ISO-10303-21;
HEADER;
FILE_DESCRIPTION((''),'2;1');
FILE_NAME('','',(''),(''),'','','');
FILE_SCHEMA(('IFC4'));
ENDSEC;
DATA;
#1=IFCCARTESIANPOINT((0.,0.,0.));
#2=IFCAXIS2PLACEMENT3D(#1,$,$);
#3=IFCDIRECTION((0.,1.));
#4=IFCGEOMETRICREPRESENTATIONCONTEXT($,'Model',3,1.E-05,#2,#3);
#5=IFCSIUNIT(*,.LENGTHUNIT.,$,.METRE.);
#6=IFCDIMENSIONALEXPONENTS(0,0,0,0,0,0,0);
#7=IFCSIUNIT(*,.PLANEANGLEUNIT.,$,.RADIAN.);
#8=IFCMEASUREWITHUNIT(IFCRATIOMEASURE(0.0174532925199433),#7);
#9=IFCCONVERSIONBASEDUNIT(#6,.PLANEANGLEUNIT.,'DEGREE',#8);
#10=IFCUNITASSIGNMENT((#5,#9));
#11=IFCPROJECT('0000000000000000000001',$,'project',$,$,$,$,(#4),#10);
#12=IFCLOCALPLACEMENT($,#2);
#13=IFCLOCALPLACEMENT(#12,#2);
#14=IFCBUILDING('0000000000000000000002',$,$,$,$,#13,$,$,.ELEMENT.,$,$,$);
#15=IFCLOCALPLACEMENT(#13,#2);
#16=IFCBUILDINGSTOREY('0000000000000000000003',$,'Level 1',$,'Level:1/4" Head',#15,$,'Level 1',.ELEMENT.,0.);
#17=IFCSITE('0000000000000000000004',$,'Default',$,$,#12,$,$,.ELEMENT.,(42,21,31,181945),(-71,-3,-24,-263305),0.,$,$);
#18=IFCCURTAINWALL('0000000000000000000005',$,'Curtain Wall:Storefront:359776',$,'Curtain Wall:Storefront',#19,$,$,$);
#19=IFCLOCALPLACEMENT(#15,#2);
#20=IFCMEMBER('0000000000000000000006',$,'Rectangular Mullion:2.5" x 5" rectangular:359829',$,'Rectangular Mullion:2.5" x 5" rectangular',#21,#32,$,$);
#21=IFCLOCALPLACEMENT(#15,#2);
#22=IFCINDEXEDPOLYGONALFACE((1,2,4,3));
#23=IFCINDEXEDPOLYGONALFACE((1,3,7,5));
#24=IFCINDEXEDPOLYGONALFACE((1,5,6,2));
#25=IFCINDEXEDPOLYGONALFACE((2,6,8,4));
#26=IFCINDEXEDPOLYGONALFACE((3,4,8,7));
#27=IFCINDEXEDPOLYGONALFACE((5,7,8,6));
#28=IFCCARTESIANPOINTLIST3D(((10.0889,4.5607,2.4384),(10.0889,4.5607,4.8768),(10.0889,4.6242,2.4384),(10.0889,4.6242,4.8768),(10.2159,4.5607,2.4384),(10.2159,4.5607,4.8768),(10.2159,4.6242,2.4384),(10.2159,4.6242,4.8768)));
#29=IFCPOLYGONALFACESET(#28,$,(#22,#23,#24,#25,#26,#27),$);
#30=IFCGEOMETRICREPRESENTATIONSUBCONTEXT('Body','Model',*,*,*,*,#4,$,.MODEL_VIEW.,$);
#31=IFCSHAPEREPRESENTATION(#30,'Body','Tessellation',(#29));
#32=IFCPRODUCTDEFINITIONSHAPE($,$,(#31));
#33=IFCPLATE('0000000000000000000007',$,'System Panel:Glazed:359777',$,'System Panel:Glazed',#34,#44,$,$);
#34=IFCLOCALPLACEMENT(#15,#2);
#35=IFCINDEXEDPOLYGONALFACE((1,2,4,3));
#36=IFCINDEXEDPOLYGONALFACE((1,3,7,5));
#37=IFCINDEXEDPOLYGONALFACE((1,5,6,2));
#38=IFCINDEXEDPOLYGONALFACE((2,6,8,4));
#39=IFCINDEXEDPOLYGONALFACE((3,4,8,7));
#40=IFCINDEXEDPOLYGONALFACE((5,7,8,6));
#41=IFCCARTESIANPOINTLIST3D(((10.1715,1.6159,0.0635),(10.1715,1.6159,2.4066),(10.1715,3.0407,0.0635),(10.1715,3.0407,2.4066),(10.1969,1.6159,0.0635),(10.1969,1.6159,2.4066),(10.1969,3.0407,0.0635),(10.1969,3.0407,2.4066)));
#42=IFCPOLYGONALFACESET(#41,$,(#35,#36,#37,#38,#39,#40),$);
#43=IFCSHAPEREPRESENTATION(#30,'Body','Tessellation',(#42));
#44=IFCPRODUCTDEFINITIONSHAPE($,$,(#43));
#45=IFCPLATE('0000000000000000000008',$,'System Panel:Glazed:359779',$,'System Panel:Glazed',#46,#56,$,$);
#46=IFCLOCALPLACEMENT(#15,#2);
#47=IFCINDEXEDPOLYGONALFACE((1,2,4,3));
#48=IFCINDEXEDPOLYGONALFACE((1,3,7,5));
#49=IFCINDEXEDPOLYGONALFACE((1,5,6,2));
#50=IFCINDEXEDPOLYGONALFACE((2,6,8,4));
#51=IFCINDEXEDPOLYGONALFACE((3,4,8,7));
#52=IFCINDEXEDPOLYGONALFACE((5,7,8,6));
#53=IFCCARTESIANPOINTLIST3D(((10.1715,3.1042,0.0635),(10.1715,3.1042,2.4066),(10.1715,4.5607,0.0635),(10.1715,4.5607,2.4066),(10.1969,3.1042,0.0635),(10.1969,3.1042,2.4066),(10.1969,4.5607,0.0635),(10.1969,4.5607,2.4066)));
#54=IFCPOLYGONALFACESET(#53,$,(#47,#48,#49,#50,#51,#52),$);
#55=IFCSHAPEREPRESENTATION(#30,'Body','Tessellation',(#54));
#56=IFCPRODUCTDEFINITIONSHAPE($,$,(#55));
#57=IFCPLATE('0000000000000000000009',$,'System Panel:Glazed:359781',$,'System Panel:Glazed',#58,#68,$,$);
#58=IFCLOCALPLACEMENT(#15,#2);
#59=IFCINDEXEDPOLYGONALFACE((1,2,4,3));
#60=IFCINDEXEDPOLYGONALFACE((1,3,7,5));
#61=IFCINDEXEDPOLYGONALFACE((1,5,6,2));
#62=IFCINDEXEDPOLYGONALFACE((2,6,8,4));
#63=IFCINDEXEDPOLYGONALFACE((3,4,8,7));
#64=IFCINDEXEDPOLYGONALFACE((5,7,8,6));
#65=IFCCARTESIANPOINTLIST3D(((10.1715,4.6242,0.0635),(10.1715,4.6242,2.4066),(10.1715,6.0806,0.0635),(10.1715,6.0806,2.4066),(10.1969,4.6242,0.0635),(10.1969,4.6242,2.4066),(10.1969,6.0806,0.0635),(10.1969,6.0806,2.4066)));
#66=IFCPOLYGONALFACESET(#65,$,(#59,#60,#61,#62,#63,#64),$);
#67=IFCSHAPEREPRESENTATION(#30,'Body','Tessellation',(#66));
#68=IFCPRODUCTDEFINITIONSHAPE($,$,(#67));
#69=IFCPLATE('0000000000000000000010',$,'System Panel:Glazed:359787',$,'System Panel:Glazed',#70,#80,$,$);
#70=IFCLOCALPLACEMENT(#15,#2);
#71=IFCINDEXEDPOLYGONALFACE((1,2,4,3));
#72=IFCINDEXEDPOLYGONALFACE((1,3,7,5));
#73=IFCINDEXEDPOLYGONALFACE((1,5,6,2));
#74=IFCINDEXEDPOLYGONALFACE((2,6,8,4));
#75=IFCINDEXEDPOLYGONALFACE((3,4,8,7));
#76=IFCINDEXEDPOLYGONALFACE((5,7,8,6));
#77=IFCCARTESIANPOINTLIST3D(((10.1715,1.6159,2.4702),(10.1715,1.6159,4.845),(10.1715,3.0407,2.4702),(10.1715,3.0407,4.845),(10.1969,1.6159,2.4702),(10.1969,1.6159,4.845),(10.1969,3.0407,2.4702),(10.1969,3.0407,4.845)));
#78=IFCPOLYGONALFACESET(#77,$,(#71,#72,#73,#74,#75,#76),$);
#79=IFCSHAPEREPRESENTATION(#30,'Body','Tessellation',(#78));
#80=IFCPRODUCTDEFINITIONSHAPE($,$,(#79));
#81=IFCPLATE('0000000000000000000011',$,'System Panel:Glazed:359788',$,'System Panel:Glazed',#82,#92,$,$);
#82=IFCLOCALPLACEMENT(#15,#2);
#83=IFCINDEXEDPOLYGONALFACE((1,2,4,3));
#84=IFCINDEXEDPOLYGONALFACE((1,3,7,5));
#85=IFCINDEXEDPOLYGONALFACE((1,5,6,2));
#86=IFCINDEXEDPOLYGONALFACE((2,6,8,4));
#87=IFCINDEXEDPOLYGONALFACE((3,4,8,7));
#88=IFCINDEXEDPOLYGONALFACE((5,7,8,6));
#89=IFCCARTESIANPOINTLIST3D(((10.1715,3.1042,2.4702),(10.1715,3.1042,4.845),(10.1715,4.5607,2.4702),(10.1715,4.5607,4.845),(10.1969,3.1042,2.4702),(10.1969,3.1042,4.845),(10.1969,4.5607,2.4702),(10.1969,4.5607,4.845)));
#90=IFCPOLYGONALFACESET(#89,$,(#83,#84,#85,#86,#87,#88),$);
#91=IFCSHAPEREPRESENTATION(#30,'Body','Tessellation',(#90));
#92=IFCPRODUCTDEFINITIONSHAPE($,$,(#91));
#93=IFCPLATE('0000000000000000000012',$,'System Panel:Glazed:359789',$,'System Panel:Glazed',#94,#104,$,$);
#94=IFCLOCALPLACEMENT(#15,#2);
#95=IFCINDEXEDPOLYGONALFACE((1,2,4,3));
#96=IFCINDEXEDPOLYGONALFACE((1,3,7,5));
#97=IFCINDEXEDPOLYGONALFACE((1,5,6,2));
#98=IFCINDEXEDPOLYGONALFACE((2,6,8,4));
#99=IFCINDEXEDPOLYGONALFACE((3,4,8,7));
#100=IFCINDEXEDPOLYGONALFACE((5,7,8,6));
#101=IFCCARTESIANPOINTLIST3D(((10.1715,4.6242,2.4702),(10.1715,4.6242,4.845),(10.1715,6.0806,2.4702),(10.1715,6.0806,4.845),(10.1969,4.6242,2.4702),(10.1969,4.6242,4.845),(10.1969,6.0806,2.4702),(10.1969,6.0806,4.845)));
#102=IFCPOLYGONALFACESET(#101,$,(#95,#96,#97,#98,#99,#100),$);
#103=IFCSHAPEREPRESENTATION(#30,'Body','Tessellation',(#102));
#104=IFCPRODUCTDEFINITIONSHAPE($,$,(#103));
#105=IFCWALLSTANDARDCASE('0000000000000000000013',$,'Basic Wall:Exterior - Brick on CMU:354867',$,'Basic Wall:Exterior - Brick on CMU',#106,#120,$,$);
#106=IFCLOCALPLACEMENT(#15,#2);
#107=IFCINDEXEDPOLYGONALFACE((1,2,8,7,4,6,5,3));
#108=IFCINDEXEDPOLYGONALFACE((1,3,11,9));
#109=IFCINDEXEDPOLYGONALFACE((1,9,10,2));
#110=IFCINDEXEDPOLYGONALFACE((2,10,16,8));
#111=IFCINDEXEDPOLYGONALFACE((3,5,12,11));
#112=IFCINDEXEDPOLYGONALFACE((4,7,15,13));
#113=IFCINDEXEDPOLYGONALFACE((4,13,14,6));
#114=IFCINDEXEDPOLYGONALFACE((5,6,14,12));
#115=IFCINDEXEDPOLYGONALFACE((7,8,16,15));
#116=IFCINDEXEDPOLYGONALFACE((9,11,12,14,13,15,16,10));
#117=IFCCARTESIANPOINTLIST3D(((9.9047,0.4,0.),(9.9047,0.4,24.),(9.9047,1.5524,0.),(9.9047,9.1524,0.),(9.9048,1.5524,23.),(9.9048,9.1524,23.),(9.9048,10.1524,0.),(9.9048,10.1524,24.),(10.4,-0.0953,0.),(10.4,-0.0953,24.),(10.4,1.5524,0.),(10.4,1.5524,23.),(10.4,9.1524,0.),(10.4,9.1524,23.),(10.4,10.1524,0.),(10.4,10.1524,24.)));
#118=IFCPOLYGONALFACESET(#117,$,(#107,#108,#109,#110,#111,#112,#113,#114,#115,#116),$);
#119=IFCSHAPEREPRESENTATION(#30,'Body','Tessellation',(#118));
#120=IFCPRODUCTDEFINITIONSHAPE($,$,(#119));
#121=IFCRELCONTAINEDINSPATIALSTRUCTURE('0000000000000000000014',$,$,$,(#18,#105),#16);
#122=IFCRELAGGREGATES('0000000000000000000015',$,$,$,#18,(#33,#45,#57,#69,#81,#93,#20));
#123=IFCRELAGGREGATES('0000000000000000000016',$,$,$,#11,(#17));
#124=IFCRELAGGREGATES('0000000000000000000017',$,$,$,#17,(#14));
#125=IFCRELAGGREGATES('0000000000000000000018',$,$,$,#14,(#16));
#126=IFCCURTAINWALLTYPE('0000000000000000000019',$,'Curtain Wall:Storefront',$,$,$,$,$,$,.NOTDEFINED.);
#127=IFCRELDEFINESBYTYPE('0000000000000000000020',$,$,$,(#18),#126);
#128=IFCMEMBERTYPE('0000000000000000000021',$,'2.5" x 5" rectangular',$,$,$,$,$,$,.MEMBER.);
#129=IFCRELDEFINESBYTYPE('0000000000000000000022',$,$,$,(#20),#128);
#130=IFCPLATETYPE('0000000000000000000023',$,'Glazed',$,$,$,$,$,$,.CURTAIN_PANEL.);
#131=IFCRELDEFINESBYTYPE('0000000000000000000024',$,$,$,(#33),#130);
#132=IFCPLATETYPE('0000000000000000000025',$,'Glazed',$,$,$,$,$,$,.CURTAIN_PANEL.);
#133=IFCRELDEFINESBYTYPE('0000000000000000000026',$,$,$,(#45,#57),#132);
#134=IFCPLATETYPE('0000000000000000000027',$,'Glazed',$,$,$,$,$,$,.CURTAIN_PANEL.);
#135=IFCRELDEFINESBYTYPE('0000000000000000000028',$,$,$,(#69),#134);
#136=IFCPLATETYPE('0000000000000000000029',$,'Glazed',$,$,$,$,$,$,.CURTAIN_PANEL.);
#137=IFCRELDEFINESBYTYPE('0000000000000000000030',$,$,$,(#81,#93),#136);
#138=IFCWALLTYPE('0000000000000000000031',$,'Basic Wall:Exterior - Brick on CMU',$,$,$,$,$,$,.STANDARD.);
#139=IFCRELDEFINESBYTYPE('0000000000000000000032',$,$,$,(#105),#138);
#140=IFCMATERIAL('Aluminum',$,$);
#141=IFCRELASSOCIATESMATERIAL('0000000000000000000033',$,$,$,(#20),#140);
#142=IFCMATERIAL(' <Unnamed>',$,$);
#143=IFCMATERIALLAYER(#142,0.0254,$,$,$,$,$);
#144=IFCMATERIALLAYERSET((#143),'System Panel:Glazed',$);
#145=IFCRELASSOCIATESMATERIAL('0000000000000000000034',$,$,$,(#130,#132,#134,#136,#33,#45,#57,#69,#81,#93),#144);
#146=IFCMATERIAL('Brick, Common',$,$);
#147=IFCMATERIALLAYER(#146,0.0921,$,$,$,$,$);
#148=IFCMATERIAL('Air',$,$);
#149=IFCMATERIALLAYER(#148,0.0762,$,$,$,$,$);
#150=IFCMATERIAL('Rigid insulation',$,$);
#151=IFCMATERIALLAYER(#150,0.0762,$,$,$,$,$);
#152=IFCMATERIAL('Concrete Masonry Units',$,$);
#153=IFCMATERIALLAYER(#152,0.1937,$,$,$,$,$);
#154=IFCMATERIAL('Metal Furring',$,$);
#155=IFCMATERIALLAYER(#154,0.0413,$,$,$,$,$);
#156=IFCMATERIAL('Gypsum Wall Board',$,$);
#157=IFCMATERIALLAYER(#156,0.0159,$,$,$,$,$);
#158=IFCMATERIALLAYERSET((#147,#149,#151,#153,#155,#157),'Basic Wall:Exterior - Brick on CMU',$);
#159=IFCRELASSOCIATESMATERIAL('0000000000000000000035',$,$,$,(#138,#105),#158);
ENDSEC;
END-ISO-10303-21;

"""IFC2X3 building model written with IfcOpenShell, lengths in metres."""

from ifc_helpers import new_model, entity, si_unit, converted_unit, direction, frame, frame_2d, origin, origin_2d_with_axis, place, context, subcontext, project, spatial, polyline, rectangle, outline, extrude, source, transform, mapped, material, layer, layer_set, layer_usage, type_object, type_shapes, element, aggregate, save


model = new_model("IFC2X3")

# Units and contexts
model_context = context("Model", 3, precision=1e-05, world=origin(), true_north=direction((0.0, 1.0)))
body_context = subcontext(model_context, "Body", "Model", "MODEL_VIEW")
ifc_project = project(units=[si_unit("LENGTHUNIT", "METRE"), converted_unit("PLANEANGLEUNIT", "DEGREE", entity("IfcRatioMeasure", 0.0174532925199433), si_unit("PLANEANGLEUNIT", "RADIAN"), dimensions=[0, 0, 0, 0, 0, 0, 0])], contexts=[model_context])

# Site, building, storey
site_placement = place(None, origin())
site = spatial("IfcSite", under=ifc_project, at=site_placement, Name="Default", CompositionType="ELEMENT", RefLatitude=(42, 21, 31, 181945), RefLongitude=(-71, -3, -24, -263305), RefElevation=0.0)
building_placement = place(site_placement, origin())
building = spatial("IfcBuilding", under=site, at=building_placement, CompositionType="ELEMENT")
storey_placement = place(building_placement, origin())
storey = spatial("IfcBuildingStorey", under=building, at=storey_placement, Name="Level 1", ObjectType="Level:1/4\" Head", LongName="Level 1", CompositionType="ELEMENT", Elevation=0.0)

# Shared definitions
curtain_wall_type = type_object("IfcCurtainWallType", Name="Curtain Wall:Storefront", PredefinedType="NOTDEFINED")
ifc_material_1 = material(Name="Aluminum")

# Curtain wall, member, plates
curtain_wall_1_placement = place(storey_placement, origin())
curtain_wall_1 = element("IfcCurtainWall", 1, at=curtain_wall_1_placement, inside=storey, type_object=curtain_wall_type, Name="Curtain Wall:Storefront:359776", ObjectType="Curtain Wall:Storefront")
member_type_1 = type_object("IfcMemberType", Name="2.5\" x 5\" rectangular", PredefinedType="MEMBER")
shared_shape_1 = source(origin(), body_context, "Body", "SweptSolid", [
    extrude(rectangle(XDim=0.127, YDim=0.0635, at=origin_2d_with_axis()), frame((0.0, 0.0, -2.4384), z_axis=(0.0, 0.0, 1.0), x_axis=(0.0, -1.0, 0.0)), (0.0, 0.0, 1.0), 2.4384),
])
type_shapes(member_type_1, [shared_shape_1])
member_1_placement = place(storey_placement, frame((10.1524, 4.5924, 2.4384), z_axis=(0.0, 0.0, -1.0), x_axis=(0.0, 1.0, 0.0)))
member_1 = element("IfcMember", 2, at=member_1_placement, type_object=member_type_1, material=ifc_material_1, Name="Rectangular Mullion:2.5\" x 5\" rectangular:359829", ObjectType="Rectangular Mullion:2.5\" x 5\" rectangular", context=body_context, shape_type="MappedRepresentation", body=[
    mapped(shared_shape_1, transform((0.0, 0.0, 0.0), scale=1.0)),
])
ifc_material_2 = material(Name=" <Unnamed>")
ifc_layer_1 = layer(ifc_material_2, 0.0254)
ifc_layer_set_1 = layer_set([ifc_layer_1], Name="System Panel:Glazed")
ifc_layer_usage_1 = layer_usage(ifc_layer_set_1, "AXIS3", "POSITIVE", 0.1042)
plate_type_1 = type_object("IfcPlateType", Name="Glazed", PredefinedType="CURTAIN_PANEL", material=ifc_layer_set_1)
shared_shape_2 = source(origin(), body_context, "Body", "SweptSolid", [
    extrude(rectangle(XDim=0.0254, YDim=1.4248, at=frame_2d((0.0, 0.0), x_axis=(1.0, 0.0))), frame((0.7124, 0.0127, 0.0), z_axis=(0.0, 0.0, 1.0), x_axis=(0.0, 1.0, 0.0)), (0.0, 0.0, 1.0), 2.3432),
])
type_shapes(plate_type_1, [shared_shape_2])
plate_1_placement = place(curtain_wall_1_placement, frame((10.1969, 1.6159, 0.0635), z_axis=(0.0, 0.0, 1.0), x_axis=(0.0, 1.0, 0.0)))
plate_1 = element("IfcPlate", 3, at=plate_1_placement, type_object=plate_type_1, material=ifc_layer_usage_1, Name="System Panel:Glazed:359777", ObjectType="System Panel:Glazed", context=body_context, shape_type="MappedRepresentation", body=[
    mapped(shared_shape_2, transform((0.0, 0.0, 0.0), scale=1.0)),
])
ifc_layer_usage_2 = layer_usage(ifc_layer_set_1, "AXIS3", "POSITIVE", 0.1042)
plate_type_2 = type_object("IfcPlateType", Name="Glazed", PredefinedType="CURTAIN_PANEL", material=ifc_layer_set_1)
shared_shape_3 = source(origin(), body_context, "Body", "SweptSolid", [
    extrude(rectangle(XDim=0.0254, YDim=1.4565, at=origin_2d_with_axis()), frame((0.7282, 0.0127, 0.0), z_axis=(0.0, 0.0, 1.0), x_axis=(0.0, 1.0, 0.0)), (0.0, 0.0, 1.0), 2.3432),
])
type_shapes(plate_type_2, [shared_shape_3])
plate_2_placement = place(curtain_wall_1_placement, frame((10.1969, 3.1042, 0.0635), z_axis=(0.0, 0.0, 1.0), x_axis=(0.0, 1.0, 0.0)))
plate_2 = element("IfcPlate", 4, at=plate_2_placement, type_object=plate_type_2, material=ifc_layer_usage_2, Name="System Panel:Glazed:359779", ObjectType="System Panel:Glazed", context=body_context, shape_type="MappedRepresentation", body=[
    mapped(shared_shape_3, transform((0.0, 0.0, 0.0), scale=1.0)),
])
ifc_layer_usage_3 = layer_usage(ifc_layer_set_1, "AXIS3", "POSITIVE", 0.1042)
plate_3_placement = place(curtain_wall_1_placement, frame((10.1969, 4.6242, 0.0635), z_axis=(0.0, 0.0, 1.0), x_axis=(0.0, 1.0, 0.0)))
plate_3 = element("IfcPlate", 5, at=plate_3_placement, type_object=plate_type_2, material=ifc_layer_usage_3, Name="System Panel:Glazed:359781", ObjectType="System Panel:Glazed", context=body_context, shape_type="MappedRepresentation", body=[
    mapped(shared_shape_3, transform((0.0, 0.0, 0.0), scale=1.0)),
])
ifc_layer_usage_4 = layer_usage(ifc_layer_set_1, "AXIS3", "POSITIVE", 0.1042)
plate_type_3 = type_object("IfcPlateType", Name="Glazed", PredefinedType="CURTAIN_PANEL", material=ifc_layer_set_1)
shared_shape_4 = source(origin(), body_context, "Body", "SweptSolid", [
    extrude(rectangle(XDim=0.0254, YDim=1.4248, at=frame_2d((0.0, 0.0), x_axis=(1.0, 0.0))), frame((0.7124, 0.0127, 0.0), z_axis=(0.0, 0.0, 1.0), x_axis=(0.0, 1.0, 0.0)), (0.0, 0.0, 1.0), 2.3749),
])
type_shapes(plate_type_3, [shared_shape_4])
plate_4_placement = place(curtain_wall_1_placement, frame((10.1969, 1.6159, 2.4701), z_axis=(0.0, 0.0, 1.0), x_axis=(0.0, 1.0, 0.0)))
plate_4 = element("IfcPlate", 6, at=plate_4_placement, type_object=plate_type_3, material=ifc_layer_usage_4, Name="System Panel:Glazed:359787", ObjectType="System Panel:Glazed", context=body_context, shape_type="MappedRepresentation", body=[
    mapped(shared_shape_4, transform((0.0, 0.0, 0.0), scale=1.0)),
])
ifc_layer_usage_5 = layer_usage(ifc_layer_set_1, "AXIS3", "POSITIVE", 0.1042)
plate_type_4 = type_object("IfcPlateType", Name="Glazed", PredefinedType="CURTAIN_PANEL", material=ifc_layer_set_1)
shared_shape_5 = source(origin(), body_context, "Body", "SweptSolid", [
    extrude(rectangle(XDim=0.0254, YDim=1.4565, at=origin_2d_with_axis()), frame((0.7282, 0.0127, 0.0), z_axis=(0.0, 0.0, 1.0), x_axis=(0.0, 1.0, 0.0)), (0.0, 0.0, 1.0), 2.3749),
])
type_shapes(plate_type_4, [shared_shape_5])
plate_5_placement = place(curtain_wall_1_placement, frame((10.1969, 3.1042, 2.4701), z_axis=(0.0, 0.0, 1.0), x_axis=(0.0, 1.0, 0.0)))
plate_5 = element("IfcPlate", 7, at=plate_5_placement, type_object=plate_type_4, material=ifc_layer_usage_5, Name="System Panel:Glazed:359788", ObjectType="System Panel:Glazed", context=body_context, shape_type="MappedRepresentation", body=[
    mapped(shared_shape_5, transform((0.0, 0.0, 0.0), scale=1.0)),
])
ifc_layer_usage_6 = layer_usage(ifc_layer_set_1, "AXIS3", "POSITIVE", 0.1042)
plate_6_placement = place(curtain_wall_1_placement, frame((10.1969, 4.6242, 2.4701), z_axis=(0.0, 0.0, 1.0), x_axis=(0.0, 1.0, 0.0)))
plate_6 = element("IfcPlate", 8, at=plate_6_placement, type_object=plate_type_4, material=ifc_layer_usage_6, Name="System Panel:Glazed:359789", ObjectType="System Panel:Glazed", context=body_context, shape_type="MappedRepresentation", body=[
    mapped(shared_shape_5, transform((0.0, 0.0, 0.0), scale=1.0)),
])
aggregate(curtain_wall_1, [plate_1, plate_2, plate_3, plate_4, plate_5, plate_6, member_1])

# Wall, opening
ifc_material_3 = material(Name="Brick, Common")
ifc_layer_2 = layer(ifc_material_3, 0.0921)
ifc_material_4 = material(Name="Air")
ifc_layer_3 = layer(ifc_material_4, 0.0762)
ifc_material_5 = material(Name="Rigid insulation")
ifc_layer_4 = layer(ifc_material_5, 0.0762)
ifc_material_6 = material(Name="Concrete Masonry Units")
ifc_layer_5 = layer(ifc_material_6, 0.1937)
ifc_material_7 = material(Name="Metal Furring")
ifc_layer_6 = layer(ifc_material_7, 0.0413)
ifc_material_8 = material(Name="Gypsum Wall Board")
ifc_layer_7 = layer(ifc_material_8, 0.0159)
ifc_layer_set_2 = layer_set([ifc_layer_2, ifc_layer_3, ifc_layer_4, ifc_layer_5, ifc_layer_6, ifc_layer_7], Name="Basic Wall:Exterior - Brick on CMU")
ifc_layer_usage_7 = layer_usage(ifc_layer_set_2, "AXIS2", "POSITIVE", -0.2477)
wall_type = type_object("IfcWallType", Name="Basic Wall:Exterior - Brick on CMU", PredefinedType="STANDARD", material=ifc_layer_set_2)
wall_placement = place(storey_placement, frame((10.1524, -0.0953, 0.0), z_axis=(0.0, 0.0, 1.0), x_axis=(0.0, 1.0, 0.0)))
wall = element("IfcWallStandardCase", 9, at=wall_placement, inside=storey, type_object=wall_type, material=ifc_layer_usage_7, Name="Basic Wall:Exterior - Brick on CMU:354867", ObjectType="Basic Wall:Exterior - Brick on CMU", context=body_context, shape_type="SweptSolid", body=[
    extrude(outline(polyline([(0.0, -0.2477), (10.2477, -0.2476), (10.2477, 0.2477), (9.8301, 0.2477), (0.4953, 0.2477), (0.0, -0.2477)])), origin(), (0.0, 0.0, 1.0), 24.0),
])
opening_placement = place(wall_placement, frame((1.6477, 0.4001, 0.0)))
element("IfcOpeningElement", 10, at=opening_placement, cuts=wall, ObjectType="Opening", context=body_context, shape_type="SweptSolid", body=[
    extrude(rectangle(XDim=23.0, YDim=7.6, at=origin_2d_with_axis()), frame((3.8, -0.8001, 11.5), z_axis=(0.0, 1.0, 0.0), x_axis=(0.0, 0.0, 1.0)), (0.0, 0.0, 1.0), 0.8001),
])

save(model, "model.ifc")
